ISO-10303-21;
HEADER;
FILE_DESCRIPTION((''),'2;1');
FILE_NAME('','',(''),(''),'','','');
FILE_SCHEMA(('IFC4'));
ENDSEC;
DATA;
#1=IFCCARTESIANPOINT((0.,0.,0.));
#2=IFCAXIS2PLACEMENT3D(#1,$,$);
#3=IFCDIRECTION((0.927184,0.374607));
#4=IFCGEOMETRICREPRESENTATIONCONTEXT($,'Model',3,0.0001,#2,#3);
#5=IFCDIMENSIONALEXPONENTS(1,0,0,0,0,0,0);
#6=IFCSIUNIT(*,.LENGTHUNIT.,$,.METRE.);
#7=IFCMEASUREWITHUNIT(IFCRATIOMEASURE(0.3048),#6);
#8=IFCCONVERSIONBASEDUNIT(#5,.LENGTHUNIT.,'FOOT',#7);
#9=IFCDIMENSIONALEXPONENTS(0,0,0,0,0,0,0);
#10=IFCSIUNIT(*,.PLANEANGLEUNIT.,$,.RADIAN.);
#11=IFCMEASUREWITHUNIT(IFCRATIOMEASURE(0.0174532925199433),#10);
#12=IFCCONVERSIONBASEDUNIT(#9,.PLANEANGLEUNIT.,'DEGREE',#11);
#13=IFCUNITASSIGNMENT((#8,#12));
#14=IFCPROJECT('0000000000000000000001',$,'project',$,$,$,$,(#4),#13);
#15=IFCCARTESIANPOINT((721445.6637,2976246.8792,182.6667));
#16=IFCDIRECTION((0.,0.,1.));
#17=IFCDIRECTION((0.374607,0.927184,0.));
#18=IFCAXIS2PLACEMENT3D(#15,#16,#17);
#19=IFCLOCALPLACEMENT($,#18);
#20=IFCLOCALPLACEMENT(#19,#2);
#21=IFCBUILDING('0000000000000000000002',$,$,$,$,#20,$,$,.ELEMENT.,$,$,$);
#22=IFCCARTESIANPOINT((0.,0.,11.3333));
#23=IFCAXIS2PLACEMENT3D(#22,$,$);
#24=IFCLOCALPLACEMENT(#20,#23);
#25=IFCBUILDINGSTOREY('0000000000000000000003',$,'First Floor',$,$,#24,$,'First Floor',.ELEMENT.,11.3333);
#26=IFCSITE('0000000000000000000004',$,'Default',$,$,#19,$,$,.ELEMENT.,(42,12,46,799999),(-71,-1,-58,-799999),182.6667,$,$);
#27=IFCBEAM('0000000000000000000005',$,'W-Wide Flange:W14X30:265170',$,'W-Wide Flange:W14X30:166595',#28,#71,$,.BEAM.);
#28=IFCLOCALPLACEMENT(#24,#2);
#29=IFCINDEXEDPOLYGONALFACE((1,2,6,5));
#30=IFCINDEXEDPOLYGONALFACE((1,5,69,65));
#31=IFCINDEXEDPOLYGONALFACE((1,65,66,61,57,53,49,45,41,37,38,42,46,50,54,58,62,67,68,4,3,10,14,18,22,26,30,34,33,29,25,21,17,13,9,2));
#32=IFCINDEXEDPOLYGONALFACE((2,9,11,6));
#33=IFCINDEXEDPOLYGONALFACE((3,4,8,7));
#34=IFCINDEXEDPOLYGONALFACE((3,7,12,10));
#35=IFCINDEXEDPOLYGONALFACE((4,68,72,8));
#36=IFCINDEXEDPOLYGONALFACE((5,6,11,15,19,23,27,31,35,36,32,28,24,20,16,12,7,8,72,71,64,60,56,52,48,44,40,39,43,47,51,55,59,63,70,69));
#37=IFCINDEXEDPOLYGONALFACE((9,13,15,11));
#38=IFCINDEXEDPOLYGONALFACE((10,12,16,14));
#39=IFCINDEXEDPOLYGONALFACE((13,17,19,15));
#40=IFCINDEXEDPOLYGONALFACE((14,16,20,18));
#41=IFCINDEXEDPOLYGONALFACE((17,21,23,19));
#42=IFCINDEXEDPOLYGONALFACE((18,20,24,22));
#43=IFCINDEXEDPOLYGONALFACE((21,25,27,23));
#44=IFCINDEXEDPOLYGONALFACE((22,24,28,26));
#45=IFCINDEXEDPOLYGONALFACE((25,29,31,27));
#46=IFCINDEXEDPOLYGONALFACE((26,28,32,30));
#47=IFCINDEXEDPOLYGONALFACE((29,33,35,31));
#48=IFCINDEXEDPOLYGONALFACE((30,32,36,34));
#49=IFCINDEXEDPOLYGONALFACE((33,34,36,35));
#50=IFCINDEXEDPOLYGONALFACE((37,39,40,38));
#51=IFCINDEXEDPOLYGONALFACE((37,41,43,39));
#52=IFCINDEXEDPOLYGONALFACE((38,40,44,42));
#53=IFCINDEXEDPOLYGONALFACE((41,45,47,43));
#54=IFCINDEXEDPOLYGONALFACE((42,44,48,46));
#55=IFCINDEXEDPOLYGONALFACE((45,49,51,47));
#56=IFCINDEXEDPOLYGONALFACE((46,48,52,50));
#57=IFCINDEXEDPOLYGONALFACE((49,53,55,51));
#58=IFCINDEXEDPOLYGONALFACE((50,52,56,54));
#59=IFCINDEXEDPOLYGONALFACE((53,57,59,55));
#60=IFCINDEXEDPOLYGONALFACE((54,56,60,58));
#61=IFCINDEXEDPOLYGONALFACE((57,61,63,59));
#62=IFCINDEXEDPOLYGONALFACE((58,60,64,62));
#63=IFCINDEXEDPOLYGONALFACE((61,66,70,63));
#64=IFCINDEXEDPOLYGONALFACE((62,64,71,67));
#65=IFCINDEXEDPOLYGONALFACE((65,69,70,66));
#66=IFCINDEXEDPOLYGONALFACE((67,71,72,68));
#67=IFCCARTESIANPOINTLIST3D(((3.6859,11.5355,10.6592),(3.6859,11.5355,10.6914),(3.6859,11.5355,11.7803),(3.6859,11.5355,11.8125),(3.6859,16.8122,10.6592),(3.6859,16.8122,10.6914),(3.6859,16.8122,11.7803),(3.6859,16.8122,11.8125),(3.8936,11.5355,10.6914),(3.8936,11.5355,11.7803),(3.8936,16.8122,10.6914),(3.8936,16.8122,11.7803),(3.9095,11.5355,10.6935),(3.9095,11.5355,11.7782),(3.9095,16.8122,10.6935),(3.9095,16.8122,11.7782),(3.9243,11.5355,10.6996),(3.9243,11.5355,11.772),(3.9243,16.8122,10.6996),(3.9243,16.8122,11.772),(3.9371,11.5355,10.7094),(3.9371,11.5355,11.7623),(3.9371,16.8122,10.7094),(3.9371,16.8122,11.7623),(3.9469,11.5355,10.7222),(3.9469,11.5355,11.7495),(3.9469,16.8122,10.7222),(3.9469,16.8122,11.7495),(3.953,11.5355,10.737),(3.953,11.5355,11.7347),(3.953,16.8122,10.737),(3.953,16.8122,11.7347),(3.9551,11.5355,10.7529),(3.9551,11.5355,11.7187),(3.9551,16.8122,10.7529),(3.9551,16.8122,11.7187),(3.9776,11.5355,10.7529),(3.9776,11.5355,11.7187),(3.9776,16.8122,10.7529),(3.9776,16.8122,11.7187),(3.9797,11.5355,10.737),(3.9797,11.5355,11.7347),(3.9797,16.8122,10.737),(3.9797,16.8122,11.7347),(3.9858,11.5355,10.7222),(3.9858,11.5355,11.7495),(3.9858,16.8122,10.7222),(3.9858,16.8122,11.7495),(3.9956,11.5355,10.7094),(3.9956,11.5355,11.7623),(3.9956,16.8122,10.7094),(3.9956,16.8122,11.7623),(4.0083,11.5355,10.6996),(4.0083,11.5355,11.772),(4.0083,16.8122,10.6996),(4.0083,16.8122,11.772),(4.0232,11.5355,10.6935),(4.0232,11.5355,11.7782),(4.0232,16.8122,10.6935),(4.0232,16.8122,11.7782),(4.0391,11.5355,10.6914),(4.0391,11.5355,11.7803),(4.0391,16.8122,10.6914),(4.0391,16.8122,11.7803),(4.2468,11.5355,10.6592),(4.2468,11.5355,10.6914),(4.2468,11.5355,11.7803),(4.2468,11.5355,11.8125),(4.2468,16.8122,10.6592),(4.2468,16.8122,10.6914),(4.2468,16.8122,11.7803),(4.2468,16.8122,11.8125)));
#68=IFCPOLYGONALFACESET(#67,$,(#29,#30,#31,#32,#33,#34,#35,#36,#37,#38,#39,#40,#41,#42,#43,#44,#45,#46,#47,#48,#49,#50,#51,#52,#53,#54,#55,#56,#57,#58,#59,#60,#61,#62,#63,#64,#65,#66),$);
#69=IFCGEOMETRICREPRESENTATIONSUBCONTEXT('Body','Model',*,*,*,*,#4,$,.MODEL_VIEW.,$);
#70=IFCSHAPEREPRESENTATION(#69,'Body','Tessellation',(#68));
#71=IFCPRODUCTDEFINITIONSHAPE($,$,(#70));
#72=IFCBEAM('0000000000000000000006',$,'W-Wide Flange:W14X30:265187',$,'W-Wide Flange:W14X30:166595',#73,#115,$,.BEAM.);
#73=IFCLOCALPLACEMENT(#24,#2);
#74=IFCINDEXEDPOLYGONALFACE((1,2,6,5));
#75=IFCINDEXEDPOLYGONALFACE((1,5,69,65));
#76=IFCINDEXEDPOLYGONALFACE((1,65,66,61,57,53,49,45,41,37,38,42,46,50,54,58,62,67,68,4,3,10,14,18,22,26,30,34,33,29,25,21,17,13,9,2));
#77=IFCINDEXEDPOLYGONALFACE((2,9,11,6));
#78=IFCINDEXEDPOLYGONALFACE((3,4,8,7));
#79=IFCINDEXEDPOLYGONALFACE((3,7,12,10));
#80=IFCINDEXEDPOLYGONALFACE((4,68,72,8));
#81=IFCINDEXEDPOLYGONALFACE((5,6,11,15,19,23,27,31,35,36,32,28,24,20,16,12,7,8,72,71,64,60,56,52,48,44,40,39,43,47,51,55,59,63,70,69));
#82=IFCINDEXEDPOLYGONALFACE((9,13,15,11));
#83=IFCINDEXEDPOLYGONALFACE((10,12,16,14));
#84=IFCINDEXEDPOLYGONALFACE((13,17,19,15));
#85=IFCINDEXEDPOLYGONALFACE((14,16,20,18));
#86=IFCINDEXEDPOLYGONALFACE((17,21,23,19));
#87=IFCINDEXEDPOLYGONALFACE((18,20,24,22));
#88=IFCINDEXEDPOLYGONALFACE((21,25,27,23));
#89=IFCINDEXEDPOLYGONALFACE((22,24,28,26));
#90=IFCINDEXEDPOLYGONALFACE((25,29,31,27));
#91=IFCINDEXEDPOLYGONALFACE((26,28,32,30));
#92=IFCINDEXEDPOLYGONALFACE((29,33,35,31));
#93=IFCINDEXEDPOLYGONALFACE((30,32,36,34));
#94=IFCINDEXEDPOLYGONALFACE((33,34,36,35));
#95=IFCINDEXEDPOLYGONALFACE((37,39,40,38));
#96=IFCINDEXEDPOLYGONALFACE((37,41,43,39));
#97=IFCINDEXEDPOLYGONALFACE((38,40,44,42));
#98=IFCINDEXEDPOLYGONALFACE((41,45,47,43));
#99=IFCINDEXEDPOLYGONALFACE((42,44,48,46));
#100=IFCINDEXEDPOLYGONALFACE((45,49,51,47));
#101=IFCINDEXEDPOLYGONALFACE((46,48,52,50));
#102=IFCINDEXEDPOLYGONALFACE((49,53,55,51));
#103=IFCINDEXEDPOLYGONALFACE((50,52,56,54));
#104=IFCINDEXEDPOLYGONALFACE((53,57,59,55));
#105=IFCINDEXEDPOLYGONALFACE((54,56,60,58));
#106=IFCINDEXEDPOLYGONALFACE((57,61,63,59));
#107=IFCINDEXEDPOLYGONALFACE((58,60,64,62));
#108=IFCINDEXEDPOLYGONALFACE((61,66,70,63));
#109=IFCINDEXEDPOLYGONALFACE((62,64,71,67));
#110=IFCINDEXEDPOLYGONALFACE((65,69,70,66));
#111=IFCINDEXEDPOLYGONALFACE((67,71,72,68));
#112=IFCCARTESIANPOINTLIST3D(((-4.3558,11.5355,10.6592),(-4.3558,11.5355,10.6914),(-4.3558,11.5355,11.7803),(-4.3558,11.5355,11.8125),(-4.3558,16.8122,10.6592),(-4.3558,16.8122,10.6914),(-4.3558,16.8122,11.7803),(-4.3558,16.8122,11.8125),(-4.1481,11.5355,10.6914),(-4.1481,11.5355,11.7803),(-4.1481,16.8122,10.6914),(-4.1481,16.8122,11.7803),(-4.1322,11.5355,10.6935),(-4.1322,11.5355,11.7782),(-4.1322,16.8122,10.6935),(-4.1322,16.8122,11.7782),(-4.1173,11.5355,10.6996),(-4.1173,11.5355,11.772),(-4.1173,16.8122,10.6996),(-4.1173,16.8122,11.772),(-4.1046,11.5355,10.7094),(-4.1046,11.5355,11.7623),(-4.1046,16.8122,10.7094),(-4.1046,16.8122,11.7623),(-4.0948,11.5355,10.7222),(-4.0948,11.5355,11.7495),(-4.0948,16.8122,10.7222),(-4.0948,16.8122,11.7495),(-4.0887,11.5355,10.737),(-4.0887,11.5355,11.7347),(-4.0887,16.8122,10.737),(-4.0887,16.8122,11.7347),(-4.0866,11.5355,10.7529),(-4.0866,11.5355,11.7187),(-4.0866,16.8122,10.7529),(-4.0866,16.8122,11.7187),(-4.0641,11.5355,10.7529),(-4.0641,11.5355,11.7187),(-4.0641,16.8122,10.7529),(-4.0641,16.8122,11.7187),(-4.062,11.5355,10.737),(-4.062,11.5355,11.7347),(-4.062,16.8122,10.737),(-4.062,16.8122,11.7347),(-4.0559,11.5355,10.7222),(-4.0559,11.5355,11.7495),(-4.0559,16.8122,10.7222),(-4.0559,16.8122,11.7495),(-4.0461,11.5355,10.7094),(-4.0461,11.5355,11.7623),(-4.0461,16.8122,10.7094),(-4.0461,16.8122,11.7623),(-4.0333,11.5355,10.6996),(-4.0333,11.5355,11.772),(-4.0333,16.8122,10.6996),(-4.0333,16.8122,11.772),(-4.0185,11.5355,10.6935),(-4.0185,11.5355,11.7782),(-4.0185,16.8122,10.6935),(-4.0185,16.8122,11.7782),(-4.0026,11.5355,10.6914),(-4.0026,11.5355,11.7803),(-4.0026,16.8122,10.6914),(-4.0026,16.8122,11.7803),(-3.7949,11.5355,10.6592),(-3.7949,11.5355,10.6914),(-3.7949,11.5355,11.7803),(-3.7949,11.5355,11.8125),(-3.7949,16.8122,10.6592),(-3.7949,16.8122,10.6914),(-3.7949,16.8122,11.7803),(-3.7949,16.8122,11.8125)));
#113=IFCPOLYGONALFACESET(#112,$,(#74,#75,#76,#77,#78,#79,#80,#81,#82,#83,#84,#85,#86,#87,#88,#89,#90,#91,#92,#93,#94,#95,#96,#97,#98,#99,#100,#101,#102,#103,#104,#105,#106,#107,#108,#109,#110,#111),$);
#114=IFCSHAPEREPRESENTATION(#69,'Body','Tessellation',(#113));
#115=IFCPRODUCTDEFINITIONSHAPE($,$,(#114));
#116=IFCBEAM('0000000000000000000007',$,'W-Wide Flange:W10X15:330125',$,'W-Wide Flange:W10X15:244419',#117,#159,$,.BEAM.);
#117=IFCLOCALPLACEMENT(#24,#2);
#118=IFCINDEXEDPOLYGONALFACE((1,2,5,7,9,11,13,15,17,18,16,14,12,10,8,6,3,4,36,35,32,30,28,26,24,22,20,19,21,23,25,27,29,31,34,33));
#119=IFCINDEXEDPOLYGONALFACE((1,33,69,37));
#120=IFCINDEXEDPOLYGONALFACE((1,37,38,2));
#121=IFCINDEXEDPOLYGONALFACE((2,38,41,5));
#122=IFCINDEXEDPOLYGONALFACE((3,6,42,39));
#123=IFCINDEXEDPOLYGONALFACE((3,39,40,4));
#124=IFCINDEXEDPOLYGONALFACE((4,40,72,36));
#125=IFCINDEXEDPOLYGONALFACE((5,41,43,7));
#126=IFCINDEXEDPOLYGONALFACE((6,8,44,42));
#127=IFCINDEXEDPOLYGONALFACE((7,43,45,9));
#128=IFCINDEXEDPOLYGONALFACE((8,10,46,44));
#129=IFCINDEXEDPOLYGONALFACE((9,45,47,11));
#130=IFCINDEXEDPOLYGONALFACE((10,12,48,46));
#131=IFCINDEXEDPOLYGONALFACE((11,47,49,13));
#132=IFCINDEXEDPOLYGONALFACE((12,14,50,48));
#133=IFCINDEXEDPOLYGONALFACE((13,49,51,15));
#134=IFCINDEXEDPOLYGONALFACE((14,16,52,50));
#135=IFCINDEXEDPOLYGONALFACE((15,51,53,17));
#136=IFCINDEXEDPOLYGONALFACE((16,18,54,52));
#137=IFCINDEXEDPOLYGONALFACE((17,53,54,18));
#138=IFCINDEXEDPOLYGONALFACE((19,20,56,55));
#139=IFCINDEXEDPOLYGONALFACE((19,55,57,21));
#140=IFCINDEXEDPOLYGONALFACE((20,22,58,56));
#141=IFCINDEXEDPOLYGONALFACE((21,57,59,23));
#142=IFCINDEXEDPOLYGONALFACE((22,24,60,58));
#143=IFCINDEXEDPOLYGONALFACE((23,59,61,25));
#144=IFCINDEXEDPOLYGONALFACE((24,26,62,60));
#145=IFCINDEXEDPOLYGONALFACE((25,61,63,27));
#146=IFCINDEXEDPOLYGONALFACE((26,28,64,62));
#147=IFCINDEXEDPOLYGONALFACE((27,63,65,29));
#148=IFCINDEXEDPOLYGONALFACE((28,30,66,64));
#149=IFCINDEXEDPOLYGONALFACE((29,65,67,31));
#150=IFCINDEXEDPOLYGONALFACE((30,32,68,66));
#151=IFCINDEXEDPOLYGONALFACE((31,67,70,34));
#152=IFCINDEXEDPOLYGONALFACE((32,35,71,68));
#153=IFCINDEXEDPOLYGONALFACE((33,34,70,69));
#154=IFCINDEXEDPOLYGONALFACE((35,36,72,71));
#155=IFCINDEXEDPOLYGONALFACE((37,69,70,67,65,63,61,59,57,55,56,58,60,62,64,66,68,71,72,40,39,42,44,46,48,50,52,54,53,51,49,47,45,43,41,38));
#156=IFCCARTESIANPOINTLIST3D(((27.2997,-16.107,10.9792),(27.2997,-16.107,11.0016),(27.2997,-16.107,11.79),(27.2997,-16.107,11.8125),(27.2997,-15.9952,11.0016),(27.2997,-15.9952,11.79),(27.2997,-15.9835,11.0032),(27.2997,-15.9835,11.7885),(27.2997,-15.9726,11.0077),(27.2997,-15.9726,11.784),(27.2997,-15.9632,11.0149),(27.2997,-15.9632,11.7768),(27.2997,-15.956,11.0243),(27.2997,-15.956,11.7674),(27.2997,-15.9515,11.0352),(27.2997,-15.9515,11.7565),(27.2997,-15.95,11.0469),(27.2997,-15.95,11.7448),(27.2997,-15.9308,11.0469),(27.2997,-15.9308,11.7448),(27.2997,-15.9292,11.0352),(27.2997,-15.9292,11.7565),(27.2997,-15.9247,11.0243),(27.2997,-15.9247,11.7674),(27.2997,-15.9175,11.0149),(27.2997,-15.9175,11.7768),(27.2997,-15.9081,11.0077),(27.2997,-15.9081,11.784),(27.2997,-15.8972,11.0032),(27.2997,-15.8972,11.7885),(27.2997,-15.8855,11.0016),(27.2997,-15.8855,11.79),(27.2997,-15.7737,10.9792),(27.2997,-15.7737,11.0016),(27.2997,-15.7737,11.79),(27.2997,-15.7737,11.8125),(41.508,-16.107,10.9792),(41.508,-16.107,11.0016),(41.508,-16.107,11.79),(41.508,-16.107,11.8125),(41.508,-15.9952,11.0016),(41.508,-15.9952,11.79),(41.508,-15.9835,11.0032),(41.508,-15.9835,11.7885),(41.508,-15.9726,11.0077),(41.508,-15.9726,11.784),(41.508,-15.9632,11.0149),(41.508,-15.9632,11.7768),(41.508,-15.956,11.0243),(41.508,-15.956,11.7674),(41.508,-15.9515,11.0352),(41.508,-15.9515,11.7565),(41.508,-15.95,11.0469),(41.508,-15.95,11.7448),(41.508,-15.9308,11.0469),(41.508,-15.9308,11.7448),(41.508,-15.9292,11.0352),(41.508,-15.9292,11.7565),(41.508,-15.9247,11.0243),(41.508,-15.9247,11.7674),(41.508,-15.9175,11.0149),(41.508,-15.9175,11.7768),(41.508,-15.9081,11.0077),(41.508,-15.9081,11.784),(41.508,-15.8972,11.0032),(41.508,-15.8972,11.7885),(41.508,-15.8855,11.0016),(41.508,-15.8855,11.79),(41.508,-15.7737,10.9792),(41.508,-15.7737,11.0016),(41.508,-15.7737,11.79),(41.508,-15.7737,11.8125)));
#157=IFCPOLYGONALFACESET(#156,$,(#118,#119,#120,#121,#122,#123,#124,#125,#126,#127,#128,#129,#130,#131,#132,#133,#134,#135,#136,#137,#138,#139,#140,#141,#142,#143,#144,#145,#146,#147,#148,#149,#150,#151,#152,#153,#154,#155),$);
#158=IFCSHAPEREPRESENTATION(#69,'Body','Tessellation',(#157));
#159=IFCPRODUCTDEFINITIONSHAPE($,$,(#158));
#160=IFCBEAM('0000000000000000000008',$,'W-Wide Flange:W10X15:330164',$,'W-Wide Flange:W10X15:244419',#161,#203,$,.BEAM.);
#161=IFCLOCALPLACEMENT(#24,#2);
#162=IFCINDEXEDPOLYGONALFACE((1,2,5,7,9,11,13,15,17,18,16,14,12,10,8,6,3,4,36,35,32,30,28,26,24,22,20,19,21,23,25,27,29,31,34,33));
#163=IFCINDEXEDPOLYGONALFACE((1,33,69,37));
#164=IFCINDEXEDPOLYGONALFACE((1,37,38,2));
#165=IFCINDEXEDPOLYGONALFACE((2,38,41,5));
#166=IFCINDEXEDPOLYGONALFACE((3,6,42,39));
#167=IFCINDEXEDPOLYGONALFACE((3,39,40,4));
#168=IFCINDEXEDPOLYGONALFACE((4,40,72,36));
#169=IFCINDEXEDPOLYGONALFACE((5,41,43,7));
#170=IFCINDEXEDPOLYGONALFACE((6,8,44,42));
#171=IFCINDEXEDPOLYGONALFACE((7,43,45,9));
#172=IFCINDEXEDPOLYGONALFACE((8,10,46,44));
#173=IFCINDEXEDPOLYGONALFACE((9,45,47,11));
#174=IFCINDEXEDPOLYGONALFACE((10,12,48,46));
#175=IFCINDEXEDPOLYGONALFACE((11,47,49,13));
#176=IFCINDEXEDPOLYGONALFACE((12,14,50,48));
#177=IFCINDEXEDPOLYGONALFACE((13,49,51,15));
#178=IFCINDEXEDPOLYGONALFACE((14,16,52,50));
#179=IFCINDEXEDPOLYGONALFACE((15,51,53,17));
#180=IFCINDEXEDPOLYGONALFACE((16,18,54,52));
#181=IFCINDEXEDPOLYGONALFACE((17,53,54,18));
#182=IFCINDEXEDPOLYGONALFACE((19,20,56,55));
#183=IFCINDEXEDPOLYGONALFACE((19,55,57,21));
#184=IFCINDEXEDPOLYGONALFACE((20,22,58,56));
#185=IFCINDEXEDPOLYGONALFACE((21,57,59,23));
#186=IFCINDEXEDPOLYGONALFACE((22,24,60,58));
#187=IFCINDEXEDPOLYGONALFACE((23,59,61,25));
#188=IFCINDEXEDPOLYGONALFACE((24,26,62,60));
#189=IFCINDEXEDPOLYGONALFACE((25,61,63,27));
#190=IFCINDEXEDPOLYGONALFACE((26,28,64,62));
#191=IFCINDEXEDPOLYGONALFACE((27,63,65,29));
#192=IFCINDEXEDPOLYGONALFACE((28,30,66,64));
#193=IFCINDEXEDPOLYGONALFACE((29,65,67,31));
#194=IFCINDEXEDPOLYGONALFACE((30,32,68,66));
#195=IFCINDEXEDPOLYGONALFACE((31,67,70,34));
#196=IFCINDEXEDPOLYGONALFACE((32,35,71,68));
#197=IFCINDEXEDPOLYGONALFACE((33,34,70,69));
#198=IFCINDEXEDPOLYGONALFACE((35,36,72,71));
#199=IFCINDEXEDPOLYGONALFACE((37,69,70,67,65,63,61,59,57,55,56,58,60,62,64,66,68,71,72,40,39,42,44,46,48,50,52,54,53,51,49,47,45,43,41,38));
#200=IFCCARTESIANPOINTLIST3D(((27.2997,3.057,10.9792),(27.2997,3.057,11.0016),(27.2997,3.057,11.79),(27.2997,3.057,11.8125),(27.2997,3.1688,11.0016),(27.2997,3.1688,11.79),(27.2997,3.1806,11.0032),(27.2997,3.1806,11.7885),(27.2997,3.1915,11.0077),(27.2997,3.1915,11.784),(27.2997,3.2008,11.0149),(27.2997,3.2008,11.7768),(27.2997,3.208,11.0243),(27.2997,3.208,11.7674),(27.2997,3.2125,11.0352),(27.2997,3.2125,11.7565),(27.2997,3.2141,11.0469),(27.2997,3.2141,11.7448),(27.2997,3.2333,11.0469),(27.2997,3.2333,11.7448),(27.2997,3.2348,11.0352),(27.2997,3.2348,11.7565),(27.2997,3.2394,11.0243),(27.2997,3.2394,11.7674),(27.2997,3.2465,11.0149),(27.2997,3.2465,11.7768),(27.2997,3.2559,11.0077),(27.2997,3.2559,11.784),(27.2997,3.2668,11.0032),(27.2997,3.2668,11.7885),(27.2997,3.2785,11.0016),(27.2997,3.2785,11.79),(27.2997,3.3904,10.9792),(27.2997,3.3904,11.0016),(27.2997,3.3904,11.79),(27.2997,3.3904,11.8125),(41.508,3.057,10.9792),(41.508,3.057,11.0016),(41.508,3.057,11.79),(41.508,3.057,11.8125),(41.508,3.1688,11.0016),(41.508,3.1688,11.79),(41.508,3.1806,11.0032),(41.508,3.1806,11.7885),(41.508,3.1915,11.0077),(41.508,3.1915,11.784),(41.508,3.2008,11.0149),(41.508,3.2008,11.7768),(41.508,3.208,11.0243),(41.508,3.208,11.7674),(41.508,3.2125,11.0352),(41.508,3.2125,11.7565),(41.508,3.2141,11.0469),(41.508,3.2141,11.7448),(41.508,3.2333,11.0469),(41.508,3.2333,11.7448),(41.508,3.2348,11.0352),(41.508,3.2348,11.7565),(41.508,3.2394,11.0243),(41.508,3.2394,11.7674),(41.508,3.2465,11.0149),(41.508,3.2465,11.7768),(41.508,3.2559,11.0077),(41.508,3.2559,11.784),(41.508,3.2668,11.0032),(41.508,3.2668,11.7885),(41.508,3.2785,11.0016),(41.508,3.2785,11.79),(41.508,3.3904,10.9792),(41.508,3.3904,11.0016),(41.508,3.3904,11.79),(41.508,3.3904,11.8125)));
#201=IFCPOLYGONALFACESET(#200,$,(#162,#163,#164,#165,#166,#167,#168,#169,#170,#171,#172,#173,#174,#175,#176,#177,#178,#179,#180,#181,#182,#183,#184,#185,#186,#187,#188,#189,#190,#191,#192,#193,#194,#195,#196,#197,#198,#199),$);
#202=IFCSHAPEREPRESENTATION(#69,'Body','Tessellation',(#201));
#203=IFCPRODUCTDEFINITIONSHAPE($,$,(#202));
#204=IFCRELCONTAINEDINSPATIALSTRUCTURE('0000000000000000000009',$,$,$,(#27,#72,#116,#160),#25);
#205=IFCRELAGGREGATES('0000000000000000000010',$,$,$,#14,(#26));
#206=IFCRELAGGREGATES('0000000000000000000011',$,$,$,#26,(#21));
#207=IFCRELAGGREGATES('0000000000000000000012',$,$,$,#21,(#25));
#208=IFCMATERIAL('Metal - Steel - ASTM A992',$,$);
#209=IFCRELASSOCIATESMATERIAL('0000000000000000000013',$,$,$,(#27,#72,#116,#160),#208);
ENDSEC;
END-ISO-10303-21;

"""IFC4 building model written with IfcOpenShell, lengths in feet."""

from ifc_helpers import new_model, entity, si_unit, converted_unit, direction, frame, frame_2d, origin, place, context, subcontext, project, spatial, i_section, extrude, material, element, save


model = new_model("IFC4")

# Units and contexts
model_context = context("Model", 3, precision=0.0001, world=origin(), true_north=direction((0.927184, 0.374607)))
body_context = subcontext(model_context, "Body", "Model", "MODEL_VIEW")
ifc_project = project(units=[converted_unit("LENGTHUNIT", "FOOT", entity("IfcRatioMeasure", 0.3048), si_unit("LENGTHUNIT", "METRE"), dimensions=[1, 0, 0, 0, 0, 0, 0]), converted_unit("PLANEANGLEUNIT", "DEGREE", entity("IfcRatioMeasure", 0.0174532925199433), si_unit("PLANEANGLEUNIT", "RADIAN"), dimensions=[0, 0, 0, 0, 0, 0, 0])], contexts=[model_context])

# Site, building, storey
site_placement = place(None, frame((721445.6637, 2976246.8792, 182.6667), z_axis=(0.0, 0.0, 1.0), x_axis=(0.374607, 0.927184, 0.0)))
site = spatial("IfcSite", under=ifc_project, at=site_placement, Name="Default", CompositionType="ELEMENT", RefLatitude=(42, 12, 46, 799999), RefLongitude=(-71, -1, -58, -799999), RefElevation=182.6667)
building_placement = place(site_placement, origin())
building = spatial("IfcBuilding", under=site, at=building_placement, CompositionType="ELEMENT")
storey_placement = place(building_placement, frame((0.0, 0.0, 11.3333)))
storey = spatial("IfcBuildingStorey", under=building, at=storey_placement, Name="First Floor", LongName="First Floor", CompositionType="ELEMENT", Elevation=11.3333)

# Shared definitions
ifc_material_1 = material(Name="Metal - Steel - ASTM A992")

# Beams
beam_1_placement = place(storey_placement, frame((3.9663, 11.1456, 11.8125), z_axis=(0.0, 0.0, 1.0), x_axis=(0.0, 1.0, 0.0)))
element("IfcBeam", 1, at=beam_1_placement, inside=storey, material=ifc_material_1, Name="W-Wide Flange:W14X30:265170", ObjectType="W-Wide Flange:W14X30:166595", PredefinedType="BEAM", context=body_context, shape_type="SweptSolid", body=[
    extrude(i_section(OverallWidth=0.5609, OverallDepth=1.1533, WebThickness=0.0225, FlangeThickness=0.0322, FilletRadius=0.0615, at=frame_2d((0.0, 0.0), x_axis=(0.0, 1.0))), frame((0.39, 0.0, -0.5767), z_axis=(1.0, 0.0, 0.0), x_axis=(0.0, 0.0, -1.0)), (0.0, 0.0, 1.0), 5.2767),
])
beam_2_placement = place(storey_placement, frame((-4.0753, 11.1456, 11.8125), z_axis=(0.0, 0.0, 1.0), x_axis=(0.0, 1.0, 0.0)))
element("IfcBeam", 2, at=beam_2_placement, inside=storey, material=ifc_material_1, Name="W-Wide Flange:W14X30:265187", ObjectType="W-Wide Flange:W14X30:166595", PredefinedType="BEAM", context=body_context, shape_type="SweptSolid", body=[
    extrude(i_section(OverallWidth=0.5609, OverallDepth=1.1533, WebThickness=0.0225, FlangeThickness=0.0322, FilletRadius=0.0615, at=frame_2d((0.0, 0.0), x_axis=(0.0, 1.0))), frame((0.39, 0.0, -0.5767), z_axis=(1.0, 0.0, 0.0), x_axis=(0.0, 0.0, -1.0)), (0.0, 0.0, 1.0), 5.2767),
])
beam_3_placement = place(storey_placement, frame((27.008, -15.9404, 11.8125)))
element("IfcBeam", 3, at=beam_3_placement, inside=storey, material=ifc_material_1, Name="W-Wide Flange:W10X15:330125", ObjectType="W-Wide Flange:W10X15:244419", PredefinedType="BEAM", context=body_context, shape_type="SweptSolid", body=[
    extrude(i_section(OverallWidth=0.3333, OverallDepth=0.8333, WebThickness=0.0192, FlangeThickness=0.0225, FilletRadius=0.0452, at=frame_2d((0.0, 0.0), x_axis=(0.0, 1.0))), frame((0.2917, 0.0, -0.4167), z_axis=(1.0, 0.0, 0.0), x_axis=(0.0, 0.0, -1.0)), (0.0, 0.0, 1.0), 14.2083),
])
beam_4_placement = place(storey_placement, frame((27.008, 3.2237, 11.8125)))
element("IfcBeam", 4, at=beam_4_placement, inside=storey, material=ifc_material_1, Name="W-Wide Flange:W10X15:330164", ObjectType="W-Wide Flange:W10X15:244419", PredefinedType="BEAM", context=body_context, shape_type="SweptSolid", body=[
    extrude(i_section(OverallWidth=0.3333, OverallDepth=0.8333, WebThickness=0.0192, FlangeThickness=0.0225, FilletRadius=0.0452, at=frame_2d((0.0, 0.0), x_axis=(0.0, 1.0))), frame((0.2917, 0.0, -0.4167), z_axis=(1.0, 0.0, 0.0), x_axis=(0.0, 0.0, -1.0)), (0.0, 0.0, 1.0), 14.2083),
])

save(model, "model.ifc")
